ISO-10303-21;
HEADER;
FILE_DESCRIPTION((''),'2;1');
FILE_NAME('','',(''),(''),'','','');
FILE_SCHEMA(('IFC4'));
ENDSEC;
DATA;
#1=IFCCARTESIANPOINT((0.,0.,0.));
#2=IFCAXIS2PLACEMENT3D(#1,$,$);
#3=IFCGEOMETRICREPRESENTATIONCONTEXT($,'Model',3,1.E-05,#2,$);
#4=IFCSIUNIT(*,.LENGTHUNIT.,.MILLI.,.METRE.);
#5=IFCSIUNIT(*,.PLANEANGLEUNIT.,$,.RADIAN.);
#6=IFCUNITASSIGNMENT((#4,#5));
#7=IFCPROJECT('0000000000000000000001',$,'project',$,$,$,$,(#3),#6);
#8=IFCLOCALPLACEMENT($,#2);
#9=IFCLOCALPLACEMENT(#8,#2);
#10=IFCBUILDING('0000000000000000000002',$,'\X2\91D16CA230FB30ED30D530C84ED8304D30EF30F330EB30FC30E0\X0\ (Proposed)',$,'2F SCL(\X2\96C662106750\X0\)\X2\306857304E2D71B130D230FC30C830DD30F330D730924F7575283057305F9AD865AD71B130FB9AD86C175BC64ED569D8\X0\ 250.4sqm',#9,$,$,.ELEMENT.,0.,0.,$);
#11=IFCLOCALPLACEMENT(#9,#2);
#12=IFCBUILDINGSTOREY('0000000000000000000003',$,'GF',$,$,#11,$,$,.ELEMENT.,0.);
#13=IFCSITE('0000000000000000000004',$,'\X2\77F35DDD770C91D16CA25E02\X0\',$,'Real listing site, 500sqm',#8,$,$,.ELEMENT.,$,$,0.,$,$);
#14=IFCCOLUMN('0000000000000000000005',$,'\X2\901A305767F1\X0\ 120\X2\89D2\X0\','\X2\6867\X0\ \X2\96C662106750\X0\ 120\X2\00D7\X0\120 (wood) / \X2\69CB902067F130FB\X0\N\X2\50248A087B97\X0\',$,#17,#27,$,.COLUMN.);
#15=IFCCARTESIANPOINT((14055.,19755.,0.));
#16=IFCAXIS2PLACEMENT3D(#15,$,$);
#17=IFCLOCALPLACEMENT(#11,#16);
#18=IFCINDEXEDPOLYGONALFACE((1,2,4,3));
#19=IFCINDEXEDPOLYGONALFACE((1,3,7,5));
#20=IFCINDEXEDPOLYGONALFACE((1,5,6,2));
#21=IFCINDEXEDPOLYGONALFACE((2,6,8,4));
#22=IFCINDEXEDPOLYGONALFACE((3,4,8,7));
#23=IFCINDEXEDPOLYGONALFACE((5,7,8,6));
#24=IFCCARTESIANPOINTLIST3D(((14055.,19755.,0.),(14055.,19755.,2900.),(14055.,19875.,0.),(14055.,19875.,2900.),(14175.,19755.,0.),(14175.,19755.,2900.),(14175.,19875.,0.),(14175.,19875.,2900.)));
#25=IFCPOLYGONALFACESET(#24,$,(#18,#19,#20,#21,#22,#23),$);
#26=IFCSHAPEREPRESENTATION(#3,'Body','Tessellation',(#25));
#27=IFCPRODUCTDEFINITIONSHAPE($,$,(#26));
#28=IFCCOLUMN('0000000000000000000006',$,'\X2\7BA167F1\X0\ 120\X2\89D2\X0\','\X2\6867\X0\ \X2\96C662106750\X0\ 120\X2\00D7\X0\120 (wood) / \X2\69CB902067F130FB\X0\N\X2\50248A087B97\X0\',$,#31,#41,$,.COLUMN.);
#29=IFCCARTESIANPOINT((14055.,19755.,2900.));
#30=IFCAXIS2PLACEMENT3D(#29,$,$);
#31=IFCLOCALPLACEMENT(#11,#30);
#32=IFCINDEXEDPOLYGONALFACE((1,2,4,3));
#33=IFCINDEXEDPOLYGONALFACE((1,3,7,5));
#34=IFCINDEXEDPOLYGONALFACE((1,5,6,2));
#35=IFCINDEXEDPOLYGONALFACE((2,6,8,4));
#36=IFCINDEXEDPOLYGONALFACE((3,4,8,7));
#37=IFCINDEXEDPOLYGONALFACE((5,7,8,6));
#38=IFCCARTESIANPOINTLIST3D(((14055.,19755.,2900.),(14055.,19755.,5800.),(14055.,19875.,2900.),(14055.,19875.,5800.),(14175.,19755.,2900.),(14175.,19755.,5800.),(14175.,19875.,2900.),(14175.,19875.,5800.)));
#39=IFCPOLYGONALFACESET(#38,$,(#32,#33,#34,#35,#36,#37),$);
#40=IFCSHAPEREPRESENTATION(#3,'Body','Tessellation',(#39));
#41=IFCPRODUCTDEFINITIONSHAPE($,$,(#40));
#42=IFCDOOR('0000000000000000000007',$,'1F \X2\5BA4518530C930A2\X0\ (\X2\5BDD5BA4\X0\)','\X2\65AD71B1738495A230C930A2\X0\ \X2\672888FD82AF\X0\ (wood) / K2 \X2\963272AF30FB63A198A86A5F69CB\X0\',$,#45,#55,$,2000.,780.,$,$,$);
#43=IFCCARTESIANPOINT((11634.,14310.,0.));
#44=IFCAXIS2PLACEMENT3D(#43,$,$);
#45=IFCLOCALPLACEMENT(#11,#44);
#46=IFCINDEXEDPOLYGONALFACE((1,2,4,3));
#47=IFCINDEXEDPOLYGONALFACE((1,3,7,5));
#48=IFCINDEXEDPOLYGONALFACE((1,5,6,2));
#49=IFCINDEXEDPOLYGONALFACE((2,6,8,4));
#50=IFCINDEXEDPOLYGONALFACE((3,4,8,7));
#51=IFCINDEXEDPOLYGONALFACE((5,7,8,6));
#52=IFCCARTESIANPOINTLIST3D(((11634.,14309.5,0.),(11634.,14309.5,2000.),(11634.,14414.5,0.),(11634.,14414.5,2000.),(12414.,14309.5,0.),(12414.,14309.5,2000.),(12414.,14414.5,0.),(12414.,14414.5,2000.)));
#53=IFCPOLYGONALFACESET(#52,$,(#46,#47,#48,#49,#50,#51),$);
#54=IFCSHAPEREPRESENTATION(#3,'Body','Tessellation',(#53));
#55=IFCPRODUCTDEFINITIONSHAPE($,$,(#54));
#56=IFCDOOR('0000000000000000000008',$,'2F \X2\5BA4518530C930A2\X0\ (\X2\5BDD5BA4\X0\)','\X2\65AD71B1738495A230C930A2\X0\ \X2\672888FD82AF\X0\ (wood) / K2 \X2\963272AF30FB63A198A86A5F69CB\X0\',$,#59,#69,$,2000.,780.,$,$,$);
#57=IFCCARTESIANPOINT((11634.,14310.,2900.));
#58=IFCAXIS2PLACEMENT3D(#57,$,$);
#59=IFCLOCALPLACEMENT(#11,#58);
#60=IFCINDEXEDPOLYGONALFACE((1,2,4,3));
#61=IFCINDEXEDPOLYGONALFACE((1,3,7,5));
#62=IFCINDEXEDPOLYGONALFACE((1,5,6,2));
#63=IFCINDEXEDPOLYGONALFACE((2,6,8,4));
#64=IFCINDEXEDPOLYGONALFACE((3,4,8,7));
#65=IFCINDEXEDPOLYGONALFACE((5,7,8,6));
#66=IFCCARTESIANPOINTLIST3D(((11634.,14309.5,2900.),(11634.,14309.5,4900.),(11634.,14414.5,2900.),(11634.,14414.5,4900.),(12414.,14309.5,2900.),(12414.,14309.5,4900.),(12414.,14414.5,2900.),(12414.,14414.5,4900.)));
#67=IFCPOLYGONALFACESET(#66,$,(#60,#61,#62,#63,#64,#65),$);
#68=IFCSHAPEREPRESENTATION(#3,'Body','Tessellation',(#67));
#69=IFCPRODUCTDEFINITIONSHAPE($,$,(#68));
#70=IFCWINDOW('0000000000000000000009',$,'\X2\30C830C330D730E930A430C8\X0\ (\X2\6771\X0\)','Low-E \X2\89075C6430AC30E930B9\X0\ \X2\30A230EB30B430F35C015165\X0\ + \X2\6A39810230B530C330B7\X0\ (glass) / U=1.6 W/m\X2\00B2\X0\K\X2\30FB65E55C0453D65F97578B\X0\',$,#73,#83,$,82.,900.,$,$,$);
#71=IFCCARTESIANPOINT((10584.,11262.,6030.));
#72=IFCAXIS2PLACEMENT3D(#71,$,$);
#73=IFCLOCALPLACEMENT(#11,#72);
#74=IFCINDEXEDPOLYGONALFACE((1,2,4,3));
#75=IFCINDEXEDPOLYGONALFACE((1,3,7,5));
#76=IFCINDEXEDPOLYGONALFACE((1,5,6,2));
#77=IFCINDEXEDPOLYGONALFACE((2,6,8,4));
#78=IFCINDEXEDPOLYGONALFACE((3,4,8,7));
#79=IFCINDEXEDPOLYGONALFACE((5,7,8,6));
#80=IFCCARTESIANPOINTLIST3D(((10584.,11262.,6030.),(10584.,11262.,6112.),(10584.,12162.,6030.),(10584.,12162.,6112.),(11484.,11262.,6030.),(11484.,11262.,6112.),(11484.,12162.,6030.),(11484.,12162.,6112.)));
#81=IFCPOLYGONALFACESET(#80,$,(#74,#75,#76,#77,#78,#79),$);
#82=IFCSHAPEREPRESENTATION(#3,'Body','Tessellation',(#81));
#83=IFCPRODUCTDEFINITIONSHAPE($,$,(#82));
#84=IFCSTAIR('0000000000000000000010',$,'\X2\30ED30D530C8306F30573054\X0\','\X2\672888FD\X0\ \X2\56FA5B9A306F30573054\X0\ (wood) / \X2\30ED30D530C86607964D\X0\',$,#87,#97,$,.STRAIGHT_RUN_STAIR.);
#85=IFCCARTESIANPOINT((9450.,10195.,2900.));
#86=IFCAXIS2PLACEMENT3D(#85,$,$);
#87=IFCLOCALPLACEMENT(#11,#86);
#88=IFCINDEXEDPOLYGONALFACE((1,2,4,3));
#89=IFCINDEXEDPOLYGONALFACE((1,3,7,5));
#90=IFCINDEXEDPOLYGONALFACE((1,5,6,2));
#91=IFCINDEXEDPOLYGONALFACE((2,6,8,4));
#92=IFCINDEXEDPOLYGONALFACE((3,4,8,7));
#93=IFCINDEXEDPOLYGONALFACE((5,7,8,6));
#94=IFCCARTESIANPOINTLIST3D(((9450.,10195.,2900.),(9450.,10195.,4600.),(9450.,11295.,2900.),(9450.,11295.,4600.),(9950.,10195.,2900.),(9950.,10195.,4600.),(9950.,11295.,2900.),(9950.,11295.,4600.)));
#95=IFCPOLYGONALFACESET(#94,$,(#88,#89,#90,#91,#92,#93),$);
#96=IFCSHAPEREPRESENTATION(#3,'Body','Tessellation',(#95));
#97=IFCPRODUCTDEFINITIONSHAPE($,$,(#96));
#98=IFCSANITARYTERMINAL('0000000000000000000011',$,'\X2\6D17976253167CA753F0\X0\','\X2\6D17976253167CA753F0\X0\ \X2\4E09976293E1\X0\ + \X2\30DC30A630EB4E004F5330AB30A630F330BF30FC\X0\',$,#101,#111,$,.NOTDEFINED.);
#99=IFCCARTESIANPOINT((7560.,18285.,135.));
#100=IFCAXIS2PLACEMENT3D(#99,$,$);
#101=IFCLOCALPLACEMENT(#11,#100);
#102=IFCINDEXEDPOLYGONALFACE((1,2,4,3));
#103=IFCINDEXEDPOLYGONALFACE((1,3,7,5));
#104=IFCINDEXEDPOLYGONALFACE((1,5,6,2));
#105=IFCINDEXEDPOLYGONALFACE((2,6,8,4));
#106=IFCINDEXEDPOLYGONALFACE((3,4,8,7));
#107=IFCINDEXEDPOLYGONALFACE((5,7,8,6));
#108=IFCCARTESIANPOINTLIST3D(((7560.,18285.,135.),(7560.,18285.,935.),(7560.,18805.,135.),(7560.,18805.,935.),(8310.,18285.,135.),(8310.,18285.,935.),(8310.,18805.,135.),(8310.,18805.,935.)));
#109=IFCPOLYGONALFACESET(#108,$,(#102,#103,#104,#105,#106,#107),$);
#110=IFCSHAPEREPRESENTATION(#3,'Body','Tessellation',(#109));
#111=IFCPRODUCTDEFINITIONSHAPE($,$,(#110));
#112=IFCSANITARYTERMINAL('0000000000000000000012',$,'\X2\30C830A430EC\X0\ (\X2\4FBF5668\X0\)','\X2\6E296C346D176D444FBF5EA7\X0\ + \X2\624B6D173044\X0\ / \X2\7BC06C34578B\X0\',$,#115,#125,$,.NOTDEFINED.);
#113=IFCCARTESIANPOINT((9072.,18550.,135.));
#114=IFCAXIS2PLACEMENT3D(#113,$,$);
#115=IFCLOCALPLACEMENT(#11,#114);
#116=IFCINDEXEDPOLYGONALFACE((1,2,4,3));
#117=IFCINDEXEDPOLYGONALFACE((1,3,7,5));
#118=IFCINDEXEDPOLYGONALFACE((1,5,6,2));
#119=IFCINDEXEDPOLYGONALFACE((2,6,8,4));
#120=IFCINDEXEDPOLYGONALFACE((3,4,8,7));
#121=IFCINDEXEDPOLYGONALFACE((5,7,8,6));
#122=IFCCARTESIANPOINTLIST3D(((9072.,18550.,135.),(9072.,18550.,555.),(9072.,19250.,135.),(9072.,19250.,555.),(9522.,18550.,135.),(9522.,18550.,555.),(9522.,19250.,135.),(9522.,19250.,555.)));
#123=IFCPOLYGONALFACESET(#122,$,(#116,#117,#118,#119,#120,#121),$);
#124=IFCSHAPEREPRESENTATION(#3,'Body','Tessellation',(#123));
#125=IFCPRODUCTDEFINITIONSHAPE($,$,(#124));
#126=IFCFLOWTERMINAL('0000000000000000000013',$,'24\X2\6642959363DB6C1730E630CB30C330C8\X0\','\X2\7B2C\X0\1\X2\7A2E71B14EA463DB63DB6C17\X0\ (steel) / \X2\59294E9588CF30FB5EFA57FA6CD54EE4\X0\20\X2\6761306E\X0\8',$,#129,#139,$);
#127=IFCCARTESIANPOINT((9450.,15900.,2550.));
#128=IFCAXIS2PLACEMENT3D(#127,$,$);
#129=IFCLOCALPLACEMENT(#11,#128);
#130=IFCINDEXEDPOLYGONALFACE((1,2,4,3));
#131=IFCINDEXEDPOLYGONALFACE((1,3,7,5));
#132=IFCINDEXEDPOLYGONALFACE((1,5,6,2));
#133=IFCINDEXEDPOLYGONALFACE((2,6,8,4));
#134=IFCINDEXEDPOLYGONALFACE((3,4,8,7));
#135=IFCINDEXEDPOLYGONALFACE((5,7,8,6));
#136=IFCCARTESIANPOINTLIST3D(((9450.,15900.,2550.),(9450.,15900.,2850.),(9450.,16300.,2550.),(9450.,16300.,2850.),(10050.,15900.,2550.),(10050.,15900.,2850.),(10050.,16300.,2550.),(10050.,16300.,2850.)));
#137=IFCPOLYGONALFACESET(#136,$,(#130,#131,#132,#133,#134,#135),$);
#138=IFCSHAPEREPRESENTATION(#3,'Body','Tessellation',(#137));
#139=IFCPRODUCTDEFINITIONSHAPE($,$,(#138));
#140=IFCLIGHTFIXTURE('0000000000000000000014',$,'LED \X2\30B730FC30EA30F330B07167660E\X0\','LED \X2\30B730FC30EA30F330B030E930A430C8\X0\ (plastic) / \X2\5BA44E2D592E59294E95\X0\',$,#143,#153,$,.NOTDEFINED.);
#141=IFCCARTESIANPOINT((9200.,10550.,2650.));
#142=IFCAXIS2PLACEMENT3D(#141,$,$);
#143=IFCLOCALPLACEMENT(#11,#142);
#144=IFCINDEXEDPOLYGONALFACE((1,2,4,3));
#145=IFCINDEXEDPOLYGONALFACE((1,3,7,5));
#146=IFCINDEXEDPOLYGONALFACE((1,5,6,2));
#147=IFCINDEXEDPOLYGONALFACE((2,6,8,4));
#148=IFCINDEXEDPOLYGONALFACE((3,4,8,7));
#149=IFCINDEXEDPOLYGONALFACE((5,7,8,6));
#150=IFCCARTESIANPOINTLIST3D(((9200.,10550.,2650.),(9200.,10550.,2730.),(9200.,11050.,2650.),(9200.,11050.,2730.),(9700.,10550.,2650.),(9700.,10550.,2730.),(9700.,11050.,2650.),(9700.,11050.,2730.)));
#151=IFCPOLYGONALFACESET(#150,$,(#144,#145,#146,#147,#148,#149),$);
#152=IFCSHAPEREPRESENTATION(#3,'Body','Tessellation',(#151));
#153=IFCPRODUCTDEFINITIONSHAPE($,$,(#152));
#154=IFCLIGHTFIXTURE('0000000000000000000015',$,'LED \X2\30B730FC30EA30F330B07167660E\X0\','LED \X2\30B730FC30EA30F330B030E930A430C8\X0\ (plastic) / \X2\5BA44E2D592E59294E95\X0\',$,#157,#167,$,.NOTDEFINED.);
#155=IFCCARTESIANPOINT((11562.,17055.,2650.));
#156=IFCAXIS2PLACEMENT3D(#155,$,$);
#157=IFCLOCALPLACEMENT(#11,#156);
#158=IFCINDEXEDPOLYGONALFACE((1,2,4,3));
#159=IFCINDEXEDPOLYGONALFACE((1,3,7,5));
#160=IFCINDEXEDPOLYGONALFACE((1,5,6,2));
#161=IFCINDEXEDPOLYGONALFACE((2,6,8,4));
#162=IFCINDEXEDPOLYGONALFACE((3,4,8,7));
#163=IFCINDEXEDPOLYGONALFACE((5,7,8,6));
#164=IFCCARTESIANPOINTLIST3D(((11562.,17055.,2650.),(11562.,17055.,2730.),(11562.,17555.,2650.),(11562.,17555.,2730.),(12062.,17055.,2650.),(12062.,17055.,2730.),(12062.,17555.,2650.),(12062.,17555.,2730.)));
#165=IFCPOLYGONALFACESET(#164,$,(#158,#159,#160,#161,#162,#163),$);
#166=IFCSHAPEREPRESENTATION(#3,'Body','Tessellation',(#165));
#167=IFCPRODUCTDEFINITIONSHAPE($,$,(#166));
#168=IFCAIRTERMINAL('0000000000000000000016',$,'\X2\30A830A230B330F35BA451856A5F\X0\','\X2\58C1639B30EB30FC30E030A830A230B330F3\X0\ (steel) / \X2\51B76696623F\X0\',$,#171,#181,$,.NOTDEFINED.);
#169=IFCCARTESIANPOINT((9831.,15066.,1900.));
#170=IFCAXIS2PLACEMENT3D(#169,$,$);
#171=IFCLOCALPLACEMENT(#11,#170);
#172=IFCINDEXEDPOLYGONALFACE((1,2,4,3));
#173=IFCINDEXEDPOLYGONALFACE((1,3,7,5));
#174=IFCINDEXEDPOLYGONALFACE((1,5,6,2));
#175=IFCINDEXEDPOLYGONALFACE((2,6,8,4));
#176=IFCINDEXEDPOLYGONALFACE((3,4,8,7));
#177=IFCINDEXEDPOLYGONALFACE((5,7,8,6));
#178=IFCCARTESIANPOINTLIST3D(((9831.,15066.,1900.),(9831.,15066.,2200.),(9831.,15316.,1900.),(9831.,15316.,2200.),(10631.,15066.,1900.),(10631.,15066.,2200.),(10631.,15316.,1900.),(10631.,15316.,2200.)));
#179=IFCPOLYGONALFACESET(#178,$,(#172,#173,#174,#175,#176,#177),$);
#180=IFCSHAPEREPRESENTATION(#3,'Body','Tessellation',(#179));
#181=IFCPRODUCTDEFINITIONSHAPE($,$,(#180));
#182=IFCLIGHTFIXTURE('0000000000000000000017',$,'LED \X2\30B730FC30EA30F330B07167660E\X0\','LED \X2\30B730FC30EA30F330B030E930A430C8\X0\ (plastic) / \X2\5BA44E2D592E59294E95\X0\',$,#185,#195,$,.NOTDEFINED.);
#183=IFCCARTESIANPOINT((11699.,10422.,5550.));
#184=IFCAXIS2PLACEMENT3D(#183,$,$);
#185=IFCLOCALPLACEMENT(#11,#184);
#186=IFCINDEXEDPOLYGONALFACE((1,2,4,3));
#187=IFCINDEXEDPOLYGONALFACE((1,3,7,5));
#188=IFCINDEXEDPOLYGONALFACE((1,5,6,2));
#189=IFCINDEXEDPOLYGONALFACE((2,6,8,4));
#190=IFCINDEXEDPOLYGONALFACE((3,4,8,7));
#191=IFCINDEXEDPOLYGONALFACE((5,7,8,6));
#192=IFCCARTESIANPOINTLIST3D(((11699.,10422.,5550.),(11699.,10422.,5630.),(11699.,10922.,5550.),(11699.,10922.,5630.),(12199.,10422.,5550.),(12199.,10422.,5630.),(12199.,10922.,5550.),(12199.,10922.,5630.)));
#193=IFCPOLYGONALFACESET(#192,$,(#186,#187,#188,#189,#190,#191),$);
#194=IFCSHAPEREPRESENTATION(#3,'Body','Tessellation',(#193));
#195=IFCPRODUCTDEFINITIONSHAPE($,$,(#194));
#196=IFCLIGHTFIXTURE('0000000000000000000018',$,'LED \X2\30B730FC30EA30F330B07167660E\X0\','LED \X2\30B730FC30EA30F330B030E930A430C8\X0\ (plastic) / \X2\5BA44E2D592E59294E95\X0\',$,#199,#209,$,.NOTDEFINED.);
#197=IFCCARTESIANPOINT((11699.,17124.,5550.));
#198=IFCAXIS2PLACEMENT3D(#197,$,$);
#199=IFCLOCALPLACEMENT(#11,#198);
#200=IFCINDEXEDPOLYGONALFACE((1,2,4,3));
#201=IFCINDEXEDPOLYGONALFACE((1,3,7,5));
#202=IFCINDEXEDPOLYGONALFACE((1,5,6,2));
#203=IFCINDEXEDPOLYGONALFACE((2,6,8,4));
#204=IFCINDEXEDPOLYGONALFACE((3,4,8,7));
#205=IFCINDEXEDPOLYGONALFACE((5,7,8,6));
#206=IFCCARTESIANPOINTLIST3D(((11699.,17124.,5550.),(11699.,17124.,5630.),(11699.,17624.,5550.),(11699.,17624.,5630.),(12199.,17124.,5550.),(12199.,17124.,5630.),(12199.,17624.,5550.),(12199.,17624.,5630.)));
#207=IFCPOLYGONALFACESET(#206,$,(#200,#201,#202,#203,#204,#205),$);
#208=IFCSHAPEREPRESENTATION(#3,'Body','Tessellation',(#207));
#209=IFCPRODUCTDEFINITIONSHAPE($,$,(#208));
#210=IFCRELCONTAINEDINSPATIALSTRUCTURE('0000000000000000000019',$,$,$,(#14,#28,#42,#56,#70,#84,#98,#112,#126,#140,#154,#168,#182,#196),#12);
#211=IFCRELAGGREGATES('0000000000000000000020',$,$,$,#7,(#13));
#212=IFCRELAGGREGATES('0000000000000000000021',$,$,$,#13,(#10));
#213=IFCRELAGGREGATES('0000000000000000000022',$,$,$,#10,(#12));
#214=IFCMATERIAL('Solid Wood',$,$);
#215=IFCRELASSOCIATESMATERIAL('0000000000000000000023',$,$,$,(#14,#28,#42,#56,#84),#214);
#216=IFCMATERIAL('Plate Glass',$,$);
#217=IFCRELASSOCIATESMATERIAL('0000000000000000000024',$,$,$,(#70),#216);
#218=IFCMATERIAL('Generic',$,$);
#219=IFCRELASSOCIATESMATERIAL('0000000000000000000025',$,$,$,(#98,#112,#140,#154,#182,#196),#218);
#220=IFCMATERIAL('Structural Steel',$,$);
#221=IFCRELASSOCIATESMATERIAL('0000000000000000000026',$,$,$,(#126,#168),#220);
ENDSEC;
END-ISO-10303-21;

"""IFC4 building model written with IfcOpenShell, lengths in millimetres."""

from ifc_helpers import new_model, si_unit, frame, frame_2d, origin, place, context, project, spatial, rectangle, extrude, material, element, save


model = new_model("IFC4")

# Units and contexts
model_context = context("Model", 3, precision=1e-05, world=origin())
ifc_project = project(units=[si_unit("LENGTHUNIT", "METRE", prefix="MILLI"), si_unit("PLANEANGLEUNIT", "RADIAN")], contexts=[model_context])

# Site, building, storey
site_placement = place(None, origin())
site = spatial("IfcSite", under=ifc_project, at=site_placement, Name="石川県金沢市", ObjectType="Real listing site, 500sqm", CompositionType="ELEMENT", RefElevation=0.0)
building_placement = place(site_placement, origin())
building = spatial("IfcBuilding", under=site, at=building_placement, Name="金沢・ロフト付きワンルーム (Proposed)", ObjectType="2F SCL(集成材)と地中熱ヒートポンプを併用した高断熱・高気密仕様 250.4sqm", CompositionType="ELEMENT", ElevationOfRefHeight=0.0, ElevationOfTerrain=0.0)
storey_placement = place(building_placement, origin())
storey = spatial("IfcBuildingStorey", under=building, at=storey_placement, Name="GF", CompositionType="ELEMENT", Elevation=0.0)

# Columns
ifc_material_1 = material(Name="Solid Wood")
column_1_placement = place(storey_placement, frame((14055.0, 19755.0, 0.0)))
element("IfcColumn", 1, at=column_1_placement, inside=storey, material=ifc_material_1, Name="通し柱 120角", Description="桧 集成材 120×120 (wood) / 構造柱・N値計算", PredefinedType="COLUMN", context=model_context, shape_type="SweptSolid", body=[
    extrude(rectangle(XDim=120.0, YDim=120.0, at=frame_2d((60.0, 60.0))), frame((14055.0, 19755.0, 0.0)), (0.0, 0.0, 1.0), 2900.0),
])
column_2_placement = place(storey_placement, frame((14055.0, 19755.0, 2900.0)))
element("IfcColumn", 2, at=column_2_placement, inside=storey, material=ifc_material_1, Name="管柱 120角", Description="桧 集成材 120×120 (wood) / 構造柱・N値計算", PredefinedType="COLUMN", context=model_context, shape_type="SweptSolid", body=[
    extrude(rectangle(XDim=120.0, YDim=120.0, at=frame_2d((60.0, 60.0))), frame((14055.0, 19755.0, 2900.0)), (0.0, 0.0, 1.0), 2900.0),
])

# Door
door_1_placement = place(storey_placement, frame((11634.0, 14310.0, 0.0)))
element("IfcDoor", 3, at=door_1_placement, inside=storey, material=ifc_material_1, Name="1F 室内ドア (寝室)", Description="断熱玄関ドア 木製芯 (wood) / K2 防犯・採風機構", OverallHeight=2000.0, OverallWidth=780.0, context=model_context, shape_type="SweptSolid", body=[
    extrude(rectangle(XDim=780.0, YDim=105.0, at=frame_2d((390.0, 52.0))), frame((11634.0, 14310.0, 0.0)), (0.0, 0.0, 1.0), 2000.0),
])

# Door
door_2_placement = place(storey_placement, frame((11634.0, 14310.0, 2900.0)))
element("IfcDoor", 4, at=door_2_placement, inside=storey, material=ifc_material_1, Name="2F 室内ドア (寝室)", Description="断熱玄関ドア 木製芯 (wood) / K2 防犯・採風機構", OverallHeight=2000.0, OverallWidth=780.0, context=model_context, shape_type="SweptSolid", body=[
    extrude(rectangle(XDim=780.0, YDim=105.0, at=frame_2d((390.0, 52.0))), frame((11634.0, 14310.0, 2900.0)), (0.0, 0.0, 1.0), 2000.0),
])

# Window
ifc_material_2 = material(Name="Plate Glass")
window_placement = place(storey_placement, frame((10584.0, 11262.0, 6030.0)))
element("IfcWindow", 5, at=window_placement, inside=storey, material=ifc_material_2, Name="トップライト (東)", Description="Low-E 複層ガラス アルゴン封入 + 樹脂サッシ (glass) / U=1.6 W/m²K・日射取得型", OverallHeight=82.0, OverallWidth=900.0, context=model_context, shape_type="SweptSolid", body=[
    extrude(rectangle(XDim=900.0, YDim=900.0, at=frame_2d((450.0, 450.0))), frame((10584.0, 11262.0, 6030.0)), (0.0, 0.0, 1.0), 82.0),
])

# Stair
stair_placement = place(storey_placement, frame((9450.0, 10195.0, 2900.0)))
element("IfcStair", 6, at=stair_placement, inside=storey, material=ifc_material_1, Name="ロフトはしご", Description="木製 固定はしご (wood) / ロフト昇降", PredefinedType="STRAIGHT_RUN_STAIR", context=model_context, shape_type="SweptSolid", body=[
    extrude(rectangle(XDim=500.0, YDim=1100.0, at=frame_2d((250.0, 550.0))), frame((9450.0, 10195.0, 2900.0)), (0.0, 0.0, 1.0), 1700.0),
])

# Sanitary terminals
ifc_material_3 = material(Name="Generic")
sanitary_terminal_1_placement = place(storey_placement, frame((7560.0, 18285.0, 135.0)))
element("IfcSanitaryTerminal", 7, at=sanitary_terminal_1_placement, inside=storey, material=ifc_material_3, Name="洗面化粧台", Description="洗面化粧台 三面鏡 + ボウル一体カウンター", PredefinedType="NOTDEFINED", context=model_context, shape_type="SweptSolid", body=[
    extrude(rectangle(XDim=750.0, YDim=520.0, at=frame_2d((375.0, 260.0))), frame((7560.0, 18285.0, 135.0)), (0.0, 0.0, 1.0), 800.0),
])
sanitary_terminal_2_placement = place(storey_placement, frame((9072.0, 18550.0, 135.0)))
element("IfcSanitaryTerminal", 8, at=sanitary_terminal_2_placement, inside=storey, material=ifc_material_3, Name="トイレ (便器)", Description="温水洗浄便座 + 手洗い / 節水型", PredefinedType="NOTDEFINED", context=model_context, shape_type="SweptSolid", body=[
    extrude(rectangle(XDim=450.0, YDim=700.0, at=frame_2d((225.0, 350.0))), frame((9072.0, 18550.0, 135.0)), (0.0, 0.0, 1.0), 420.0),
])

# Flow terminal
ifc_material_4 = material(Name="Structural Steel")
flow_terminal_placement = place(storey_placement, frame((9450.0, 15900.0, 2550.0)))
element("IfcFlowTerminal", 9, at=flow_terminal_placement, inside=storey, material=ifc_material_4, Name="24時間換気ユニット", Description="第1種熱交換換気 (steel) / 天井裏・建基法令20条の8", context=model_context, shape_type="SweptSolid", body=[
    extrude(rectangle(XDim=600.0, YDim=400.0, at=frame_2d((300.0, 200.0))), frame((9450.0, 15900.0, 2550.0)), (0.0, 0.0, 1.0), 300.0),
])

# Light fixtures
light_fixture_1_placement = place(storey_placement, frame((9200.0, 10550.0, 2650.0)))
element("IfcLightFixture", 10, at=light_fixture_1_placement, inside=storey, material=ifc_material_3, Name="LED シーリング照明", Description="LED シーリングライト (plastic) / 室中央天井", PredefinedType="NOTDEFINED", context=model_context, shape_type="SweptSolid", body=[
    extrude(rectangle(XDim=500.0, YDim=500.0, at=frame_2d((250.0, 250.0))), frame((9200.0, 10550.0, 2650.0)), (0.0, 0.0, 1.0), 80.0),
])
light_fixture_2_placement = place(storey_placement, frame((11562.0, 17055.0, 2650.0)))
element("IfcLightFixture", 11, at=light_fixture_2_placement, inside=storey, material=ifc_material_3, Name="LED シーリング照明", Description="LED シーリングライト (plastic) / 室中央天井", PredefinedType="NOTDEFINED", context=model_context, shape_type="SweptSolid", body=[
    extrude(rectangle(XDim=500.0, YDim=500.0, at=frame_2d((250.0, 250.0))), frame((11562.0, 17055.0, 2650.0)), (0.0, 0.0, 1.0), 80.0),
])

# Air terminal
air_terminal_placement = place(storey_placement, frame((9831.0, 15066.0, 1900.0)))
element("IfcAirTerminal", 12, at=air_terminal_placement, inside=storey, material=ifc_material_4, Name="エアコン室内機", Description="壁掛ルームエアコン (steel) / 冷暖房", PredefinedType="NOTDEFINED", context=model_context, shape_type="SweptSolid", body=[
    extrude(rectangle(XDim=800.0, YDim=250.0, at=frame_2d((400.0, 125.0))), frame((9831.0, 15066.0, 1900.0)), (0.0, 0.0, 1.0), 300.0),
])

# Light fixtures
light_fixture_3_placement = place(storey_placement, frame((11699.0, 10422.0, 5550.0)))
element("IfcLightFixture", 13, at=light_fixture_3_placement, inside=storey, material=ifc_material_3, Name="LED シーリング照明", Description="LED シーリングライト (plastic) / 室中央天井", PredefinedType="NOTDEFINED", context=model_context, shape_type="SweptSolid", body=[
    extrude(rectangle(XDim=500.0, YDim=500.0, at=frame_2d((250.0, 250.0))), frame((11699.0, 10422.0, 5550.0)), (0.0, 0.0, 1.0), 80.0),
])
light_fixture_4_placement = place(storey_placement, frame((11699.0, 17124.0, 5550.0)))
element("IfcLightFixture", 14, at=light_fixture_4_placement, inside=storey, material=ifc_material_3, Name="LED シーリング照明", Description="LED シーリングライト (plastic) / 室中央天井", PredefinedType="NOTDEFINED", context=model_context, shape_type="SweptSolid", body=[
    extrude(rectangle(XDim=500.0, YDim=500.0, at=frame_2d((250.0, 250.0))), frame((11699.0, 17124.0, 5550.0)), (0.0, 0.0, 1.0), 80.0),
])

save(model, "model.ifc")
